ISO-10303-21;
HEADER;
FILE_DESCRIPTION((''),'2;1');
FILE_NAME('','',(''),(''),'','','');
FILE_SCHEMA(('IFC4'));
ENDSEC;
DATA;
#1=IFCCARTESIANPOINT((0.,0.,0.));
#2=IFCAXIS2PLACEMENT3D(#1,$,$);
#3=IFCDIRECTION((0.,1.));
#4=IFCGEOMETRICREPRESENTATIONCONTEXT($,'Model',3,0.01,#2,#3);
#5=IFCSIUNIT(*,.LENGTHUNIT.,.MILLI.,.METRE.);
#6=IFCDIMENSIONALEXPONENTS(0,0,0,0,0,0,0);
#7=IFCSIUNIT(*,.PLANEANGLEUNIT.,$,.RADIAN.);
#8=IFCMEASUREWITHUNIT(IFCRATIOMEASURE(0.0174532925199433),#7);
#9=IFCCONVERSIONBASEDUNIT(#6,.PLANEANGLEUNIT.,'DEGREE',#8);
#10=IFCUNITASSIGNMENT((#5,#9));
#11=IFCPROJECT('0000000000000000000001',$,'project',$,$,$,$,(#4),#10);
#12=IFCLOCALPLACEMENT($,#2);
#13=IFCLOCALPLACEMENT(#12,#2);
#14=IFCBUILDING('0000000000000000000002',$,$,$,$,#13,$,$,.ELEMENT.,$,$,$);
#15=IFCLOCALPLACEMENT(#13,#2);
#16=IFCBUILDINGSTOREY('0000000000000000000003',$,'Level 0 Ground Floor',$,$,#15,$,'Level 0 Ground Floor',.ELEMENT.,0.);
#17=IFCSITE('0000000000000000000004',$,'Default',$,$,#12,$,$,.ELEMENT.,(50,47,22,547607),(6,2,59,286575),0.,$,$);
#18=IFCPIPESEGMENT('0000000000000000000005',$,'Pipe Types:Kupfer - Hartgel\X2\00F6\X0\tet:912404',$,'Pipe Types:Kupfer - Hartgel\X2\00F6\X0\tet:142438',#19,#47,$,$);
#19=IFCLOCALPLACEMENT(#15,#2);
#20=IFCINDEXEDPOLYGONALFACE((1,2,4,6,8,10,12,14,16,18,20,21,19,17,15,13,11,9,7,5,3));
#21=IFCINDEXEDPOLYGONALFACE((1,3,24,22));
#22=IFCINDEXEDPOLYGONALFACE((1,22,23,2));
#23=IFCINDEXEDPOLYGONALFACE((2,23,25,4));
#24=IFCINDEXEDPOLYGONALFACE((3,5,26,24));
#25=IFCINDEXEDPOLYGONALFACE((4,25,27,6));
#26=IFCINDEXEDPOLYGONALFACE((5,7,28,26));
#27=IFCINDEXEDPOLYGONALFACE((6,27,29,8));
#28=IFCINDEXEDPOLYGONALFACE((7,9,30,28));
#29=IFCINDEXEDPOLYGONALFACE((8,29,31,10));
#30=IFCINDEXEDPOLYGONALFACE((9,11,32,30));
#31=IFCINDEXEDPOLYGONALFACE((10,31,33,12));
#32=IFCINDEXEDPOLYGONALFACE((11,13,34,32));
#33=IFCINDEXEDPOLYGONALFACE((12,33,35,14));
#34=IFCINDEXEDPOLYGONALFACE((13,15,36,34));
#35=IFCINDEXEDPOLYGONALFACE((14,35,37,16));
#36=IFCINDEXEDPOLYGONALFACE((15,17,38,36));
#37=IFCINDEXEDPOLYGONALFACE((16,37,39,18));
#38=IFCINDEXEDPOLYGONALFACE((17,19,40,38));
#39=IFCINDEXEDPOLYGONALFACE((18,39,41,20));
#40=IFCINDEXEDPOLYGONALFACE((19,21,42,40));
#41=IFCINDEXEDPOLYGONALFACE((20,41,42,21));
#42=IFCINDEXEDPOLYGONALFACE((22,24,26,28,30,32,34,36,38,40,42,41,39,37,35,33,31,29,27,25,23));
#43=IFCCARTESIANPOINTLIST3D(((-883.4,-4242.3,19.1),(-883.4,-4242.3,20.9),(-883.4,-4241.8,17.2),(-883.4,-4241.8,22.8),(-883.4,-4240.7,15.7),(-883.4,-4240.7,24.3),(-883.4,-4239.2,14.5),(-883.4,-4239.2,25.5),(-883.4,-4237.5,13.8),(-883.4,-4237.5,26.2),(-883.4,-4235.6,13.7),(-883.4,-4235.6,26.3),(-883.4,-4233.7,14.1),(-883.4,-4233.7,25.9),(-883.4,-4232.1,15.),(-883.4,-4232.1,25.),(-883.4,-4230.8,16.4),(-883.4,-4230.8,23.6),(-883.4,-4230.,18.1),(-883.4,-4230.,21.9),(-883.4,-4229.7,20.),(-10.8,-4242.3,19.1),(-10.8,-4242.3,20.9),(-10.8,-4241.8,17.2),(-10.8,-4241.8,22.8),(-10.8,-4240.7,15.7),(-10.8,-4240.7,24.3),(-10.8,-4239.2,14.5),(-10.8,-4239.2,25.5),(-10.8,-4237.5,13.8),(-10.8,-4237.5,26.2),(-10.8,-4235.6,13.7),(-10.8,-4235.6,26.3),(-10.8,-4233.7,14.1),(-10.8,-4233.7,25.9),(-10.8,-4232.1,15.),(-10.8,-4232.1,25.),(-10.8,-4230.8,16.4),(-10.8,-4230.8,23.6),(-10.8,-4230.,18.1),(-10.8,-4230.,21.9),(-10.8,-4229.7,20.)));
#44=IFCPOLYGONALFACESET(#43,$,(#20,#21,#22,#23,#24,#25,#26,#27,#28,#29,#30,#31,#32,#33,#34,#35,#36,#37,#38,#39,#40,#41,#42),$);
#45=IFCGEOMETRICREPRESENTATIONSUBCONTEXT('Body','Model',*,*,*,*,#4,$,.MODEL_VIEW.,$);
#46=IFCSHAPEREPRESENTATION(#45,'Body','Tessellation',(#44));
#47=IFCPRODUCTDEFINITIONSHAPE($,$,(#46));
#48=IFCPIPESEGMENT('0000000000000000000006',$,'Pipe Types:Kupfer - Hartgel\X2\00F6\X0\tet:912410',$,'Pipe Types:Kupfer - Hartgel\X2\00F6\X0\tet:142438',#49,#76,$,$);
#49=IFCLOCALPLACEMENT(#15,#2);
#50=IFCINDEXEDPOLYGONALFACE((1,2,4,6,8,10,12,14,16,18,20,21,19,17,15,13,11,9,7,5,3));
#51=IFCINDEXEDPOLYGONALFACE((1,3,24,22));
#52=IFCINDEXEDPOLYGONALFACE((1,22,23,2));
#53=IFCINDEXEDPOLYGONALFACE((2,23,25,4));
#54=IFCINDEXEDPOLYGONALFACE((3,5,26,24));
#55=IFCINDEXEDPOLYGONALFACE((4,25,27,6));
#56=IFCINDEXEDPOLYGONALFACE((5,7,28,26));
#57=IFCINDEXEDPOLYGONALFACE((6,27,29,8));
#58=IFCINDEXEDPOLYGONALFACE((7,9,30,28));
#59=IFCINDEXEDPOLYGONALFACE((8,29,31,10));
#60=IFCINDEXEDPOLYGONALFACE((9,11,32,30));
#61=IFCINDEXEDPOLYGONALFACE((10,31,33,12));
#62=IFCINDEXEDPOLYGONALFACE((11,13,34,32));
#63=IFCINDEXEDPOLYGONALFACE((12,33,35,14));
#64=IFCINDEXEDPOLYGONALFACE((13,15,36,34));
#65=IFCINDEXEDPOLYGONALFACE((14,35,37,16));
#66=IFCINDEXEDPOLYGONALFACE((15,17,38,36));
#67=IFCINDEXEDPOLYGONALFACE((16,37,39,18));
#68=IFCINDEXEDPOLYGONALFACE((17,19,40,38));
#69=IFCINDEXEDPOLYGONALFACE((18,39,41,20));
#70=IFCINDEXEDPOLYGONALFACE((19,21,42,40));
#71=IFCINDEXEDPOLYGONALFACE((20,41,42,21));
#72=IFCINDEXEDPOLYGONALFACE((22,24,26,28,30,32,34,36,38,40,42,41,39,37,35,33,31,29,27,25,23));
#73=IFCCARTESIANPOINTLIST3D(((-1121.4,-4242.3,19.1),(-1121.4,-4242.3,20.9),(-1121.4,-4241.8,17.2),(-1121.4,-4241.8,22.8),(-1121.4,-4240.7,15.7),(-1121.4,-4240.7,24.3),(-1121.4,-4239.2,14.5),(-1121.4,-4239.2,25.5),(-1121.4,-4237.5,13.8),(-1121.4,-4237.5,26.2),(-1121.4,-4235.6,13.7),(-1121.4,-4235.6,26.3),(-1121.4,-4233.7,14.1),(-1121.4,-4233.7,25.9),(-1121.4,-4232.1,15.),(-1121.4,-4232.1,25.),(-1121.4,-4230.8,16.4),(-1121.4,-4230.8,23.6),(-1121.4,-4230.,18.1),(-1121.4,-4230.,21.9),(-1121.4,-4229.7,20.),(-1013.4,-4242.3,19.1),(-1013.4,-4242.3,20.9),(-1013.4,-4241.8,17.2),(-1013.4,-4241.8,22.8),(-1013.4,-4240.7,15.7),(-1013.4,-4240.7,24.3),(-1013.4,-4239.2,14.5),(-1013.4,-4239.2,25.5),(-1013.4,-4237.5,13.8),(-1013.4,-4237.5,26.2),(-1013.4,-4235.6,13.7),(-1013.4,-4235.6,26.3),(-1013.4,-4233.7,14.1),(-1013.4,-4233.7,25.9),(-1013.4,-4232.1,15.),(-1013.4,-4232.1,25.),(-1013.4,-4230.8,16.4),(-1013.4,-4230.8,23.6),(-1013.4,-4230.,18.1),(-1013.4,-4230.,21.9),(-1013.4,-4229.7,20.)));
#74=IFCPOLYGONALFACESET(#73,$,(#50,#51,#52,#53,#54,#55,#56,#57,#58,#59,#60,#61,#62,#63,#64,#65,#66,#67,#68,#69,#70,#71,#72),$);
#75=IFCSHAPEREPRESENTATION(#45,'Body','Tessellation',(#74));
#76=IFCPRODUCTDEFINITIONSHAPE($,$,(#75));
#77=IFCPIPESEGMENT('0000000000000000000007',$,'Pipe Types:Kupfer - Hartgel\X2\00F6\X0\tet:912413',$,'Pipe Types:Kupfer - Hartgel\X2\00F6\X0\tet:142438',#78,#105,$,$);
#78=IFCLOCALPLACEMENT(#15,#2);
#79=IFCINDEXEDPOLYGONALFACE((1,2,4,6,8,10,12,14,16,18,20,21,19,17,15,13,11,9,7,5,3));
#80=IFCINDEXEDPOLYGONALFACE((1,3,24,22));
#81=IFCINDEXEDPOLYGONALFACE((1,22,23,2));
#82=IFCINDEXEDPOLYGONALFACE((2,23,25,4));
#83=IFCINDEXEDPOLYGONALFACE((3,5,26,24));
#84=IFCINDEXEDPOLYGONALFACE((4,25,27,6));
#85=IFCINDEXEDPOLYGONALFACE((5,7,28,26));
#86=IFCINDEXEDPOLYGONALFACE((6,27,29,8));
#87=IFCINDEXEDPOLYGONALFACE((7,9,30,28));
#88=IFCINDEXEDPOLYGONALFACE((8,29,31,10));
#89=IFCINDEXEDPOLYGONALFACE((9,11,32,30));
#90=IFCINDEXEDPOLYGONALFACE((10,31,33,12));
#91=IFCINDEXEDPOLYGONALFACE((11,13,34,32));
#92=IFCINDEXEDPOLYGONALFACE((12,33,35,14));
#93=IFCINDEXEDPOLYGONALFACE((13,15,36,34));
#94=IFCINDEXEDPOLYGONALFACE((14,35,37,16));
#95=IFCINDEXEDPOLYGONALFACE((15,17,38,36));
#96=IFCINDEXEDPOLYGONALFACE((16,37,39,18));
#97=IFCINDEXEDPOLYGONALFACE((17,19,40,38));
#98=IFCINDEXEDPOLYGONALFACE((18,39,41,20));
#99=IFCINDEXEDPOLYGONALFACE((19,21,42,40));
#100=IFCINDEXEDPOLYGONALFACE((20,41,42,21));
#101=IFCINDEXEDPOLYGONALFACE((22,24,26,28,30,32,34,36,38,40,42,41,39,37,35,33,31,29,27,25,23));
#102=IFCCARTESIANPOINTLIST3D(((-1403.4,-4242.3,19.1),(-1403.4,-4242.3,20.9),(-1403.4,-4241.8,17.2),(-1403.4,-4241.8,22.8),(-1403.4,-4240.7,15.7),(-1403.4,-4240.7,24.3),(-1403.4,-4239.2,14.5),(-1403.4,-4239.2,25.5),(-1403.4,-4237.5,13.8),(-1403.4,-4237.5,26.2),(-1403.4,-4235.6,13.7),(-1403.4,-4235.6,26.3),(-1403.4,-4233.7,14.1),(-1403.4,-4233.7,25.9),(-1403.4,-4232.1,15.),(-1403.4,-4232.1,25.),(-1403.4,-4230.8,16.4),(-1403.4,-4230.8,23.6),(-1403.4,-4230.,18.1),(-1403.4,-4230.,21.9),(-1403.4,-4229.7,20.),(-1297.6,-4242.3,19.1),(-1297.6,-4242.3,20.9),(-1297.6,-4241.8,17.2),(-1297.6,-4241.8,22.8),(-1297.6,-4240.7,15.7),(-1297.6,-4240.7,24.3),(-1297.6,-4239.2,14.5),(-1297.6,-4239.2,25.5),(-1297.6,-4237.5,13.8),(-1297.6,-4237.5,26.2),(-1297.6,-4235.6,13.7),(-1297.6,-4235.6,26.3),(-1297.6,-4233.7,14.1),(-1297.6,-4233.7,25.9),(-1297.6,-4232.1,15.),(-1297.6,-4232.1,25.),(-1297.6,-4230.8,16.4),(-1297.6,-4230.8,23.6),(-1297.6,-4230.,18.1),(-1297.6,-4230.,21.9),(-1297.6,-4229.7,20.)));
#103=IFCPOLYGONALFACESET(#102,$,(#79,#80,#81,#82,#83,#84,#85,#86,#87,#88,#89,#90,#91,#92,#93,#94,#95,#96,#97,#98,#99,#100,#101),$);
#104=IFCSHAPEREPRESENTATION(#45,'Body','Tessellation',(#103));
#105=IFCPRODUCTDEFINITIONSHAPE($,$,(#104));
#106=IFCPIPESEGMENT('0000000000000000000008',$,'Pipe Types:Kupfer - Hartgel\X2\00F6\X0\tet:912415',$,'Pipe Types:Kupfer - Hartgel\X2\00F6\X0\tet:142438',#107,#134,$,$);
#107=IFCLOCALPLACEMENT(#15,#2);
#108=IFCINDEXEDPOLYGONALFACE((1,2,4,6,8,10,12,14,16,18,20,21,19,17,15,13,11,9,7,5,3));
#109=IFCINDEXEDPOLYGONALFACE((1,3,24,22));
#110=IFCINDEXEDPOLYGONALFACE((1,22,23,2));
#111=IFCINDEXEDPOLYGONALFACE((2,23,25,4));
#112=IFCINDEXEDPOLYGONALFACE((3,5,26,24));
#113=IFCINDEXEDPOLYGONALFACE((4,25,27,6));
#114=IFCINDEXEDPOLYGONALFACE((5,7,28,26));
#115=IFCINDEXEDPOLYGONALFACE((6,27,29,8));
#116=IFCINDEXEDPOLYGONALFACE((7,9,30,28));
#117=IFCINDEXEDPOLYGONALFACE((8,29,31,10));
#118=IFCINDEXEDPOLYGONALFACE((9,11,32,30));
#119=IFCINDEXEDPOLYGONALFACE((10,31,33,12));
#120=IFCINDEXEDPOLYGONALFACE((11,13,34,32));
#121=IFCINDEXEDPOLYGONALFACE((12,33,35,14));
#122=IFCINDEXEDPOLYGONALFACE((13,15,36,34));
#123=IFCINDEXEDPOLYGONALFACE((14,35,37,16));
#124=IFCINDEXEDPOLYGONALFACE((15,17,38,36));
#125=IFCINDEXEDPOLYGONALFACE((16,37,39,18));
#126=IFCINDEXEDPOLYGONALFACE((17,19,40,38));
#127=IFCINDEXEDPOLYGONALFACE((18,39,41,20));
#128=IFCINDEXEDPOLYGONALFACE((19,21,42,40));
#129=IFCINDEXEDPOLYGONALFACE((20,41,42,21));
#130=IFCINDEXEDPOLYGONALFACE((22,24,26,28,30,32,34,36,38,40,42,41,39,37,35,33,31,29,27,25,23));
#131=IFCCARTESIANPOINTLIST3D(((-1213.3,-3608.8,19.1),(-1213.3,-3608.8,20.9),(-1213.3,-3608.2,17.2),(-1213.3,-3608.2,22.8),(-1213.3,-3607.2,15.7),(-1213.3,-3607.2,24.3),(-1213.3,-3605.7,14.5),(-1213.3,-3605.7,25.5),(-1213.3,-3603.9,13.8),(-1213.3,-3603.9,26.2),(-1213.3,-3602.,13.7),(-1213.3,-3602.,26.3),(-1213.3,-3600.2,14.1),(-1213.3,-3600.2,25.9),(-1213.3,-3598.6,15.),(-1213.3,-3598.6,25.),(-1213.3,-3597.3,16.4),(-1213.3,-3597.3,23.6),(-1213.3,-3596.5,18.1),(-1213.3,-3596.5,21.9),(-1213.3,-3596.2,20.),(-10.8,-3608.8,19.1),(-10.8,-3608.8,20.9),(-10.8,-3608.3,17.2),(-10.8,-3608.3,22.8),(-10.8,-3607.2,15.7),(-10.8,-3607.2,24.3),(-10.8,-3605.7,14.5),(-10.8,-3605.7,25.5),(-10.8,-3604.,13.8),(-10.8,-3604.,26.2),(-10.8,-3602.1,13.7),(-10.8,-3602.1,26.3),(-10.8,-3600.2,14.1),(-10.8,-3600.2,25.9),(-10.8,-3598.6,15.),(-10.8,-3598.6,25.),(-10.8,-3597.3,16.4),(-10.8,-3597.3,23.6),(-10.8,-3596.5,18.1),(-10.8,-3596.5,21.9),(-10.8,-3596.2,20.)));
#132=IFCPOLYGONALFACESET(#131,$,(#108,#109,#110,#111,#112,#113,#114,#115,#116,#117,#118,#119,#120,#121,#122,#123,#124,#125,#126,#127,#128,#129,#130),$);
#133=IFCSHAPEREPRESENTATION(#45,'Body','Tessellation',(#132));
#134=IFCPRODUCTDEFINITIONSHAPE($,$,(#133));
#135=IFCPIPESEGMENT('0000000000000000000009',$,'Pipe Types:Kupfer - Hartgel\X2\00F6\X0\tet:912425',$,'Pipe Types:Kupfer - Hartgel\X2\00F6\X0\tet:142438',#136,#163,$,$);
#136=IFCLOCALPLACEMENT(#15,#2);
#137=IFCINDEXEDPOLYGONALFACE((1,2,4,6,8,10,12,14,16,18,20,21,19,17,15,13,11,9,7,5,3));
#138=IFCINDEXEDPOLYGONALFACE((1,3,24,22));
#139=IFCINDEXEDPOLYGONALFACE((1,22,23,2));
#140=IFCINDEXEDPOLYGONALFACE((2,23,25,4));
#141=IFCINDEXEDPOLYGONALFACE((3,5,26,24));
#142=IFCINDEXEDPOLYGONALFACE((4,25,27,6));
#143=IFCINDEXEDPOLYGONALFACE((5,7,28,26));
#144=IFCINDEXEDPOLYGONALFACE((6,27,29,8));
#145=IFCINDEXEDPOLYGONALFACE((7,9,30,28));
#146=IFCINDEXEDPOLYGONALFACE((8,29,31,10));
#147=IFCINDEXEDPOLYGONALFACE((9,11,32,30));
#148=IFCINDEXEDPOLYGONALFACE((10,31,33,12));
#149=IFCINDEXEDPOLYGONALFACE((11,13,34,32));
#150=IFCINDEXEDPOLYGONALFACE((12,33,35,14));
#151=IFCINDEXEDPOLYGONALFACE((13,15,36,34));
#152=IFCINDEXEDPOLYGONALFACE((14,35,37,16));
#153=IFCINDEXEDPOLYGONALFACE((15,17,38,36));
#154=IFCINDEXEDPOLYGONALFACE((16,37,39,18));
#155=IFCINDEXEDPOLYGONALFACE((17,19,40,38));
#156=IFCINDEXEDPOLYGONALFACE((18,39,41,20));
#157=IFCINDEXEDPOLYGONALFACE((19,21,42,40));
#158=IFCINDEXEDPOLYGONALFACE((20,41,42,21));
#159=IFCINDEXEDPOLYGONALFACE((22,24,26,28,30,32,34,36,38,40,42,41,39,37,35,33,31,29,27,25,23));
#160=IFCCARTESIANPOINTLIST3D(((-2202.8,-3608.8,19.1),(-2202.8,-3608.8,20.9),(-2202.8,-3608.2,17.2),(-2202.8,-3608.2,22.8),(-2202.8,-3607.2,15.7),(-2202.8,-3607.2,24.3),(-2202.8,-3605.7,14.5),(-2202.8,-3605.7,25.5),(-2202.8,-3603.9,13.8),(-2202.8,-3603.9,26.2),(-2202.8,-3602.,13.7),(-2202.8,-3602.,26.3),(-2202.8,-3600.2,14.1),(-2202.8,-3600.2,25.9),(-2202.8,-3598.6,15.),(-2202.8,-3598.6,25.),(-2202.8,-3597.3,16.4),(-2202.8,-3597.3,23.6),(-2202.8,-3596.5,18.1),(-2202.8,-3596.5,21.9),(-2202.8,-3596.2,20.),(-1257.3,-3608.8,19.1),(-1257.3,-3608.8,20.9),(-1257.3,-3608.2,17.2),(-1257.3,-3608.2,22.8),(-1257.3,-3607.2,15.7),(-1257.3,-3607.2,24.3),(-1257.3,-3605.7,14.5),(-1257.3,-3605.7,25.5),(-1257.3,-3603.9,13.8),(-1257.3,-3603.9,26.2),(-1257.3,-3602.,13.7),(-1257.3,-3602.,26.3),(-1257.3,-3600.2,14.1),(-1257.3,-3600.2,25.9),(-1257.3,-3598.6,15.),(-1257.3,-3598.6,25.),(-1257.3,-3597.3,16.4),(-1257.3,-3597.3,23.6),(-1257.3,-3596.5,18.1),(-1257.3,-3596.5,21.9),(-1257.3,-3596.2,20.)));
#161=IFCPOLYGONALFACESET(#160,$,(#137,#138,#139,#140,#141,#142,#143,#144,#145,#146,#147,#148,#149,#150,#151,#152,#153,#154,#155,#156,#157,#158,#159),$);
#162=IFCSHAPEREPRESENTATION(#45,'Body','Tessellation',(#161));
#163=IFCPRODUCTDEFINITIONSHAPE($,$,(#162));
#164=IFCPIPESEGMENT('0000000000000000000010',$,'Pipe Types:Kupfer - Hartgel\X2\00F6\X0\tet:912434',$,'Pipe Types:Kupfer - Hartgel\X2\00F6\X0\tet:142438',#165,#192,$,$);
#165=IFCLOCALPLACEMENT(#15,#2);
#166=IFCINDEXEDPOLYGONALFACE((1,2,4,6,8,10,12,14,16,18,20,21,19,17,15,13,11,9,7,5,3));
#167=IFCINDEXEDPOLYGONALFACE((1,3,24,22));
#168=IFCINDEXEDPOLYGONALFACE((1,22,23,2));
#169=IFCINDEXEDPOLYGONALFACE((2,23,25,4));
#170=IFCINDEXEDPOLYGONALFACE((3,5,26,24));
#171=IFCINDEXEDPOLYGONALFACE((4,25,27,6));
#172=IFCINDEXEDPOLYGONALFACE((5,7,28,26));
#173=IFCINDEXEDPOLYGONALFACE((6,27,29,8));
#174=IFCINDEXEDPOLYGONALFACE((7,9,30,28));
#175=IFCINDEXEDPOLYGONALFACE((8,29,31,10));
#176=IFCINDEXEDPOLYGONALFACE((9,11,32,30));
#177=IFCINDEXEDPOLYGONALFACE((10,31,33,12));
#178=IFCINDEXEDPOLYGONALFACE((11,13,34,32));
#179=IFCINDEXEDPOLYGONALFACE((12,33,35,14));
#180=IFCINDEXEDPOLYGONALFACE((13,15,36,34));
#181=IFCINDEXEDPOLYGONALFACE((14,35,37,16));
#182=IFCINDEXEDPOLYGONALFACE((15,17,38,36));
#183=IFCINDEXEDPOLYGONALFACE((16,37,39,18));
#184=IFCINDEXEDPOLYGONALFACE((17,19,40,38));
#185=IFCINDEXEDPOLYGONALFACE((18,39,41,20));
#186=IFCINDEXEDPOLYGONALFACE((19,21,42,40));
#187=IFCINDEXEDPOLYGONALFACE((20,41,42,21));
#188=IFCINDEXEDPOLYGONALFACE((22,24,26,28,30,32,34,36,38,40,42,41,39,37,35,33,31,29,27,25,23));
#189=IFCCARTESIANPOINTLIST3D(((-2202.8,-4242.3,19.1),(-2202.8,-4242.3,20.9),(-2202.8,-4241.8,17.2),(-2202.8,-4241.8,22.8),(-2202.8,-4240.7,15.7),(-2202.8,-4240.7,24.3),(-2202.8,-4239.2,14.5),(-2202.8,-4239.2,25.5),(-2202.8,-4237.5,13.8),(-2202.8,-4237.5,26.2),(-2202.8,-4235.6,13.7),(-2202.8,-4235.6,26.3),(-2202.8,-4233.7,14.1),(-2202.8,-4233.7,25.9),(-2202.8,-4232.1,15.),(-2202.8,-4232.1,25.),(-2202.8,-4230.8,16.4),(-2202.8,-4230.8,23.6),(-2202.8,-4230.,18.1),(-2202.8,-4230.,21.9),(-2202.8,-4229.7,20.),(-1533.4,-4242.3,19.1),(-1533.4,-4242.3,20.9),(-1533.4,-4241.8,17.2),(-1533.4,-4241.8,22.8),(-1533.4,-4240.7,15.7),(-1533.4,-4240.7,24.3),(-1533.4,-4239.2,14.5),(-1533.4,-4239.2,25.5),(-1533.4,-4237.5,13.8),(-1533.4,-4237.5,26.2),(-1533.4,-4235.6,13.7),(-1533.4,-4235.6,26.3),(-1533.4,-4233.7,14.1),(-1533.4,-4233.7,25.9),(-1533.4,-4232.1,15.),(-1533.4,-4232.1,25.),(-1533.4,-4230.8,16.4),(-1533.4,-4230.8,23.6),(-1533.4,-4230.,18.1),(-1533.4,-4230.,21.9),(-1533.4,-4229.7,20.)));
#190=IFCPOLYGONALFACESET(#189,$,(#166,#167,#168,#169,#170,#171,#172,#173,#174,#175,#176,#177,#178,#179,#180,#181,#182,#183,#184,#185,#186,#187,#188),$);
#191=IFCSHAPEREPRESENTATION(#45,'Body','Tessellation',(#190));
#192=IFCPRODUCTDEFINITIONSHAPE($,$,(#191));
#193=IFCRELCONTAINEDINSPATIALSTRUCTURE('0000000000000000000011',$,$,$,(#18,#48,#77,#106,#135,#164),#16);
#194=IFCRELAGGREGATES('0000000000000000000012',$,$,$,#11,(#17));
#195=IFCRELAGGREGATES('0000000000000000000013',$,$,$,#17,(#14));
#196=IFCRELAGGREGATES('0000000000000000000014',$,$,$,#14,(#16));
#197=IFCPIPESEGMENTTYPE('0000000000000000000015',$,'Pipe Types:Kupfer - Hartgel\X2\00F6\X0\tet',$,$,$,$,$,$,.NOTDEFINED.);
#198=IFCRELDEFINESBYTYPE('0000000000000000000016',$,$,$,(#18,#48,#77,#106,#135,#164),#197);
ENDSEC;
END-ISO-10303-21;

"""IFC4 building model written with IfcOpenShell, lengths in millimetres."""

from ifc_helpers import new_model, entity, si_unit, converted_unit, direction, frame, frame_2d, origin, place, context, subcontext, project, spatial, circle, extrude, type_object, element, save


model = new_model("IFC4")

# Units and contexts
model_context = context("Model", 3, precision=0.01, world=origin(), true_north=direction((0.0, 1.0)))
body_context = subcontext(model_context, "Body", "Model", "MODEL_VIEW")
ifc_project = project(units=[si_unit("LENGTHUNIT", "METRE", prefix="MILLI"), converted_unit("PLANEANGLEUNIT", "DEGREE", entity("IfcRatioMeasure", 0.0174532925199433), si_unit("PLANEANGLEUNIT", "RADIAN"), dimensions=[0, 0, 0, 0, 0, 0, 0])], contexts=[model_context])

# Site, building, storey
site_placement = place(None, origin())
site = spatial("IfcSite", under=ifc_project, at=site_placement, Name="Default", CompositionType="ELEMENT", RefLatitude=(50, 47, 22, 547607), RefLongitude=(6, 2, 59, 286575), RefElevation=0.0)
building_placement = place(site_placement, origin())
building = spatial("IfcBuilding", under=site, at=building_placement, CompositionType="ELEMENT")
storey_placement = place(building_placement, origin())
storey = spatial("IfcBuildingStorey", under=building, at=storey_placement, Name="Level 0 Ground Floor", LongName="Level 0 Ground Floor", CompositionType="ELEMENT", Elevation=0.0)

# Pipe segments
pipe_segment_type = type_object("IfcPipeSegmentType", Name="Pipe Types:Kupfer - Hartgelötet", PredefinedType="NOTDEFINED")
pipe_segment_1_placement = place(storey_placement, frame((-883.4, -4244.0, 12.1)))
element("IfcPipeSegment", 1, at=pipe_segment_1_placement, inside=storey, type_object=pipe_segment_type, Name="Pipe Types:Kupfer - Hartgelötet:912404", ObjectType="Pipe Types:Kupfer - Hartgelötet:142438", context=body_context, shape_type="SweptSolid", body=[
    extrude(circle(Radius=6.3, at=frame_2d((0.0, 0.0), x_axis=(1.0, 0.0))), frame((0.0, 7.9, 7.9), z_axis=(1.0, 0.0, 0.0), x_axis=(0.0, 1.0, 0.0)), (0.0, 0.0, 1.0), 872.6),
])
pipe_segment_2_placement = place(storey_placement, frame((-1121.4, -4244.0, 12.1)))
element("IfcPipeSegment", 2, at=pipe_segment_2_placement, inside=storey, type_object=pipe_segment_type, Name="Pipe Types:Kupfer - Hartgelötet:912410", ObjectType="Pipe Types:Kupfer - Hartgelötet:142438", context=body_context, shape_type="SweptSolid", body=[
    extrude(circle(Radius=6.3, at=frame_2d((0.0, 0.0), x_axis=(1.0, 0.0))), frame((0.0, 7.9, 7.9), z_axis=(1.0, 0.0, 0.0), x_axis=(0.0, 1.0, 0.0)), (0.0, 0.0, 1.0), 108.0),
])
pipe_segment_3_placement = place(storey_placement, frame((-1403.4, -4244.0, 12.1)))
element("IfcPipeSegment", 3, at=pipe_segment_3_placement, inside=storey, type_object=pipe_segment_type, Name="Pipe Types:Kupfer - Hartgelötet:912413", ObjectType="Pipe Types:Kupfer - Hartgelötet:142438", context=body_context, shape_type="SweptSolid", body=[
    extrude(circle(Radius=6.3, at=frame_2d((0.0, 0.0), x_axis=(1.0, 0.0))), frame((0.0, 7.9, 7.9), z_axis=(1.0, 0.0, 0.0), x_axis=(0.0, 1.0, 0.0)), (0.0, 0.0, 1.0), 105.8),
])
pipe_segment_4_placement = place(storey_placement, frame((-1213.3, -3610.5, 12.1)))
element("IfcPipeSegment", 4, at=pipe_segment_4_placement, inside=storey, type_object=pipe_segment_type, Name="Pipe Types:Kupfer - Hartgelötet:912415", ObjectType="Pipe Types:Kupfer - Hartgelötet:142438", context=body_context, shape_type="SweptSolid", body=[
    extrude(circle(Radius=6.3, at=frame_2d((0.0, 0.0), x_axis=(1.0, 0.0))), frame((0.0, 8.0, 7.9), z_axis=(1.0, -0.000035, 0.0), x_axis=(0.000035, 1.0, 0.0)), (0.0, 0.0, 1.0), 1202.5),
])
pipe_segment_5_placement = place(storey_placement, frame((-2202.8, -3610.5, 12.1)))
element("IfcPipeSegment", 5, at=pipe_segment_5_placement, inside=storey, type_object=pipe_segment_type, Name="Pipe Types:Kupfer - Hartgelötet:912425", ObjectType="Pipe Types:Kupfer - Hartgelötet:142438", context=body_context, shape_type="SweptSolid", body=[
    extrude(circle(Radius=6.3, at=frame_2d((0.0, 0.0), x_axis=(1.0, 0.0))), frame((0.0, 7.9, 7.9), z_axis=(1.0, 0.0, 0.0), x_axis=(0.0, 1.0, 0.0)), (0.0, 0.0, 1.0), 945.5),
])
pipe_segment_6_placement = place(storey_placement, frame((-2202.8, -4244.0, 12.1)))
element("IfcPipeSegment", 6, at=pipe_segment_6_placement, inside=storey, type_object=pipe_segment_type, Name="Pipe Types:Kupfer - Hartgelötet:912434", ObjectType="Pipe Types:Kupfer - Hartgelötet:142438", context=body_context, shape_type="SweptSolid", body=[
    extrude(circle(Radius=6.3, at=frame_2d((0.0, 0.0), x_axis=(1.0, 0.0))), frame((0.0, 7.9, 7.9), z_axis=(1.0, 0.000044, 0.0), x_axis=(-0.000044, 1.0, 0.0)), (0.0, 0.0, 1.0), 669.4),
])

save(model, "model.ifc")
